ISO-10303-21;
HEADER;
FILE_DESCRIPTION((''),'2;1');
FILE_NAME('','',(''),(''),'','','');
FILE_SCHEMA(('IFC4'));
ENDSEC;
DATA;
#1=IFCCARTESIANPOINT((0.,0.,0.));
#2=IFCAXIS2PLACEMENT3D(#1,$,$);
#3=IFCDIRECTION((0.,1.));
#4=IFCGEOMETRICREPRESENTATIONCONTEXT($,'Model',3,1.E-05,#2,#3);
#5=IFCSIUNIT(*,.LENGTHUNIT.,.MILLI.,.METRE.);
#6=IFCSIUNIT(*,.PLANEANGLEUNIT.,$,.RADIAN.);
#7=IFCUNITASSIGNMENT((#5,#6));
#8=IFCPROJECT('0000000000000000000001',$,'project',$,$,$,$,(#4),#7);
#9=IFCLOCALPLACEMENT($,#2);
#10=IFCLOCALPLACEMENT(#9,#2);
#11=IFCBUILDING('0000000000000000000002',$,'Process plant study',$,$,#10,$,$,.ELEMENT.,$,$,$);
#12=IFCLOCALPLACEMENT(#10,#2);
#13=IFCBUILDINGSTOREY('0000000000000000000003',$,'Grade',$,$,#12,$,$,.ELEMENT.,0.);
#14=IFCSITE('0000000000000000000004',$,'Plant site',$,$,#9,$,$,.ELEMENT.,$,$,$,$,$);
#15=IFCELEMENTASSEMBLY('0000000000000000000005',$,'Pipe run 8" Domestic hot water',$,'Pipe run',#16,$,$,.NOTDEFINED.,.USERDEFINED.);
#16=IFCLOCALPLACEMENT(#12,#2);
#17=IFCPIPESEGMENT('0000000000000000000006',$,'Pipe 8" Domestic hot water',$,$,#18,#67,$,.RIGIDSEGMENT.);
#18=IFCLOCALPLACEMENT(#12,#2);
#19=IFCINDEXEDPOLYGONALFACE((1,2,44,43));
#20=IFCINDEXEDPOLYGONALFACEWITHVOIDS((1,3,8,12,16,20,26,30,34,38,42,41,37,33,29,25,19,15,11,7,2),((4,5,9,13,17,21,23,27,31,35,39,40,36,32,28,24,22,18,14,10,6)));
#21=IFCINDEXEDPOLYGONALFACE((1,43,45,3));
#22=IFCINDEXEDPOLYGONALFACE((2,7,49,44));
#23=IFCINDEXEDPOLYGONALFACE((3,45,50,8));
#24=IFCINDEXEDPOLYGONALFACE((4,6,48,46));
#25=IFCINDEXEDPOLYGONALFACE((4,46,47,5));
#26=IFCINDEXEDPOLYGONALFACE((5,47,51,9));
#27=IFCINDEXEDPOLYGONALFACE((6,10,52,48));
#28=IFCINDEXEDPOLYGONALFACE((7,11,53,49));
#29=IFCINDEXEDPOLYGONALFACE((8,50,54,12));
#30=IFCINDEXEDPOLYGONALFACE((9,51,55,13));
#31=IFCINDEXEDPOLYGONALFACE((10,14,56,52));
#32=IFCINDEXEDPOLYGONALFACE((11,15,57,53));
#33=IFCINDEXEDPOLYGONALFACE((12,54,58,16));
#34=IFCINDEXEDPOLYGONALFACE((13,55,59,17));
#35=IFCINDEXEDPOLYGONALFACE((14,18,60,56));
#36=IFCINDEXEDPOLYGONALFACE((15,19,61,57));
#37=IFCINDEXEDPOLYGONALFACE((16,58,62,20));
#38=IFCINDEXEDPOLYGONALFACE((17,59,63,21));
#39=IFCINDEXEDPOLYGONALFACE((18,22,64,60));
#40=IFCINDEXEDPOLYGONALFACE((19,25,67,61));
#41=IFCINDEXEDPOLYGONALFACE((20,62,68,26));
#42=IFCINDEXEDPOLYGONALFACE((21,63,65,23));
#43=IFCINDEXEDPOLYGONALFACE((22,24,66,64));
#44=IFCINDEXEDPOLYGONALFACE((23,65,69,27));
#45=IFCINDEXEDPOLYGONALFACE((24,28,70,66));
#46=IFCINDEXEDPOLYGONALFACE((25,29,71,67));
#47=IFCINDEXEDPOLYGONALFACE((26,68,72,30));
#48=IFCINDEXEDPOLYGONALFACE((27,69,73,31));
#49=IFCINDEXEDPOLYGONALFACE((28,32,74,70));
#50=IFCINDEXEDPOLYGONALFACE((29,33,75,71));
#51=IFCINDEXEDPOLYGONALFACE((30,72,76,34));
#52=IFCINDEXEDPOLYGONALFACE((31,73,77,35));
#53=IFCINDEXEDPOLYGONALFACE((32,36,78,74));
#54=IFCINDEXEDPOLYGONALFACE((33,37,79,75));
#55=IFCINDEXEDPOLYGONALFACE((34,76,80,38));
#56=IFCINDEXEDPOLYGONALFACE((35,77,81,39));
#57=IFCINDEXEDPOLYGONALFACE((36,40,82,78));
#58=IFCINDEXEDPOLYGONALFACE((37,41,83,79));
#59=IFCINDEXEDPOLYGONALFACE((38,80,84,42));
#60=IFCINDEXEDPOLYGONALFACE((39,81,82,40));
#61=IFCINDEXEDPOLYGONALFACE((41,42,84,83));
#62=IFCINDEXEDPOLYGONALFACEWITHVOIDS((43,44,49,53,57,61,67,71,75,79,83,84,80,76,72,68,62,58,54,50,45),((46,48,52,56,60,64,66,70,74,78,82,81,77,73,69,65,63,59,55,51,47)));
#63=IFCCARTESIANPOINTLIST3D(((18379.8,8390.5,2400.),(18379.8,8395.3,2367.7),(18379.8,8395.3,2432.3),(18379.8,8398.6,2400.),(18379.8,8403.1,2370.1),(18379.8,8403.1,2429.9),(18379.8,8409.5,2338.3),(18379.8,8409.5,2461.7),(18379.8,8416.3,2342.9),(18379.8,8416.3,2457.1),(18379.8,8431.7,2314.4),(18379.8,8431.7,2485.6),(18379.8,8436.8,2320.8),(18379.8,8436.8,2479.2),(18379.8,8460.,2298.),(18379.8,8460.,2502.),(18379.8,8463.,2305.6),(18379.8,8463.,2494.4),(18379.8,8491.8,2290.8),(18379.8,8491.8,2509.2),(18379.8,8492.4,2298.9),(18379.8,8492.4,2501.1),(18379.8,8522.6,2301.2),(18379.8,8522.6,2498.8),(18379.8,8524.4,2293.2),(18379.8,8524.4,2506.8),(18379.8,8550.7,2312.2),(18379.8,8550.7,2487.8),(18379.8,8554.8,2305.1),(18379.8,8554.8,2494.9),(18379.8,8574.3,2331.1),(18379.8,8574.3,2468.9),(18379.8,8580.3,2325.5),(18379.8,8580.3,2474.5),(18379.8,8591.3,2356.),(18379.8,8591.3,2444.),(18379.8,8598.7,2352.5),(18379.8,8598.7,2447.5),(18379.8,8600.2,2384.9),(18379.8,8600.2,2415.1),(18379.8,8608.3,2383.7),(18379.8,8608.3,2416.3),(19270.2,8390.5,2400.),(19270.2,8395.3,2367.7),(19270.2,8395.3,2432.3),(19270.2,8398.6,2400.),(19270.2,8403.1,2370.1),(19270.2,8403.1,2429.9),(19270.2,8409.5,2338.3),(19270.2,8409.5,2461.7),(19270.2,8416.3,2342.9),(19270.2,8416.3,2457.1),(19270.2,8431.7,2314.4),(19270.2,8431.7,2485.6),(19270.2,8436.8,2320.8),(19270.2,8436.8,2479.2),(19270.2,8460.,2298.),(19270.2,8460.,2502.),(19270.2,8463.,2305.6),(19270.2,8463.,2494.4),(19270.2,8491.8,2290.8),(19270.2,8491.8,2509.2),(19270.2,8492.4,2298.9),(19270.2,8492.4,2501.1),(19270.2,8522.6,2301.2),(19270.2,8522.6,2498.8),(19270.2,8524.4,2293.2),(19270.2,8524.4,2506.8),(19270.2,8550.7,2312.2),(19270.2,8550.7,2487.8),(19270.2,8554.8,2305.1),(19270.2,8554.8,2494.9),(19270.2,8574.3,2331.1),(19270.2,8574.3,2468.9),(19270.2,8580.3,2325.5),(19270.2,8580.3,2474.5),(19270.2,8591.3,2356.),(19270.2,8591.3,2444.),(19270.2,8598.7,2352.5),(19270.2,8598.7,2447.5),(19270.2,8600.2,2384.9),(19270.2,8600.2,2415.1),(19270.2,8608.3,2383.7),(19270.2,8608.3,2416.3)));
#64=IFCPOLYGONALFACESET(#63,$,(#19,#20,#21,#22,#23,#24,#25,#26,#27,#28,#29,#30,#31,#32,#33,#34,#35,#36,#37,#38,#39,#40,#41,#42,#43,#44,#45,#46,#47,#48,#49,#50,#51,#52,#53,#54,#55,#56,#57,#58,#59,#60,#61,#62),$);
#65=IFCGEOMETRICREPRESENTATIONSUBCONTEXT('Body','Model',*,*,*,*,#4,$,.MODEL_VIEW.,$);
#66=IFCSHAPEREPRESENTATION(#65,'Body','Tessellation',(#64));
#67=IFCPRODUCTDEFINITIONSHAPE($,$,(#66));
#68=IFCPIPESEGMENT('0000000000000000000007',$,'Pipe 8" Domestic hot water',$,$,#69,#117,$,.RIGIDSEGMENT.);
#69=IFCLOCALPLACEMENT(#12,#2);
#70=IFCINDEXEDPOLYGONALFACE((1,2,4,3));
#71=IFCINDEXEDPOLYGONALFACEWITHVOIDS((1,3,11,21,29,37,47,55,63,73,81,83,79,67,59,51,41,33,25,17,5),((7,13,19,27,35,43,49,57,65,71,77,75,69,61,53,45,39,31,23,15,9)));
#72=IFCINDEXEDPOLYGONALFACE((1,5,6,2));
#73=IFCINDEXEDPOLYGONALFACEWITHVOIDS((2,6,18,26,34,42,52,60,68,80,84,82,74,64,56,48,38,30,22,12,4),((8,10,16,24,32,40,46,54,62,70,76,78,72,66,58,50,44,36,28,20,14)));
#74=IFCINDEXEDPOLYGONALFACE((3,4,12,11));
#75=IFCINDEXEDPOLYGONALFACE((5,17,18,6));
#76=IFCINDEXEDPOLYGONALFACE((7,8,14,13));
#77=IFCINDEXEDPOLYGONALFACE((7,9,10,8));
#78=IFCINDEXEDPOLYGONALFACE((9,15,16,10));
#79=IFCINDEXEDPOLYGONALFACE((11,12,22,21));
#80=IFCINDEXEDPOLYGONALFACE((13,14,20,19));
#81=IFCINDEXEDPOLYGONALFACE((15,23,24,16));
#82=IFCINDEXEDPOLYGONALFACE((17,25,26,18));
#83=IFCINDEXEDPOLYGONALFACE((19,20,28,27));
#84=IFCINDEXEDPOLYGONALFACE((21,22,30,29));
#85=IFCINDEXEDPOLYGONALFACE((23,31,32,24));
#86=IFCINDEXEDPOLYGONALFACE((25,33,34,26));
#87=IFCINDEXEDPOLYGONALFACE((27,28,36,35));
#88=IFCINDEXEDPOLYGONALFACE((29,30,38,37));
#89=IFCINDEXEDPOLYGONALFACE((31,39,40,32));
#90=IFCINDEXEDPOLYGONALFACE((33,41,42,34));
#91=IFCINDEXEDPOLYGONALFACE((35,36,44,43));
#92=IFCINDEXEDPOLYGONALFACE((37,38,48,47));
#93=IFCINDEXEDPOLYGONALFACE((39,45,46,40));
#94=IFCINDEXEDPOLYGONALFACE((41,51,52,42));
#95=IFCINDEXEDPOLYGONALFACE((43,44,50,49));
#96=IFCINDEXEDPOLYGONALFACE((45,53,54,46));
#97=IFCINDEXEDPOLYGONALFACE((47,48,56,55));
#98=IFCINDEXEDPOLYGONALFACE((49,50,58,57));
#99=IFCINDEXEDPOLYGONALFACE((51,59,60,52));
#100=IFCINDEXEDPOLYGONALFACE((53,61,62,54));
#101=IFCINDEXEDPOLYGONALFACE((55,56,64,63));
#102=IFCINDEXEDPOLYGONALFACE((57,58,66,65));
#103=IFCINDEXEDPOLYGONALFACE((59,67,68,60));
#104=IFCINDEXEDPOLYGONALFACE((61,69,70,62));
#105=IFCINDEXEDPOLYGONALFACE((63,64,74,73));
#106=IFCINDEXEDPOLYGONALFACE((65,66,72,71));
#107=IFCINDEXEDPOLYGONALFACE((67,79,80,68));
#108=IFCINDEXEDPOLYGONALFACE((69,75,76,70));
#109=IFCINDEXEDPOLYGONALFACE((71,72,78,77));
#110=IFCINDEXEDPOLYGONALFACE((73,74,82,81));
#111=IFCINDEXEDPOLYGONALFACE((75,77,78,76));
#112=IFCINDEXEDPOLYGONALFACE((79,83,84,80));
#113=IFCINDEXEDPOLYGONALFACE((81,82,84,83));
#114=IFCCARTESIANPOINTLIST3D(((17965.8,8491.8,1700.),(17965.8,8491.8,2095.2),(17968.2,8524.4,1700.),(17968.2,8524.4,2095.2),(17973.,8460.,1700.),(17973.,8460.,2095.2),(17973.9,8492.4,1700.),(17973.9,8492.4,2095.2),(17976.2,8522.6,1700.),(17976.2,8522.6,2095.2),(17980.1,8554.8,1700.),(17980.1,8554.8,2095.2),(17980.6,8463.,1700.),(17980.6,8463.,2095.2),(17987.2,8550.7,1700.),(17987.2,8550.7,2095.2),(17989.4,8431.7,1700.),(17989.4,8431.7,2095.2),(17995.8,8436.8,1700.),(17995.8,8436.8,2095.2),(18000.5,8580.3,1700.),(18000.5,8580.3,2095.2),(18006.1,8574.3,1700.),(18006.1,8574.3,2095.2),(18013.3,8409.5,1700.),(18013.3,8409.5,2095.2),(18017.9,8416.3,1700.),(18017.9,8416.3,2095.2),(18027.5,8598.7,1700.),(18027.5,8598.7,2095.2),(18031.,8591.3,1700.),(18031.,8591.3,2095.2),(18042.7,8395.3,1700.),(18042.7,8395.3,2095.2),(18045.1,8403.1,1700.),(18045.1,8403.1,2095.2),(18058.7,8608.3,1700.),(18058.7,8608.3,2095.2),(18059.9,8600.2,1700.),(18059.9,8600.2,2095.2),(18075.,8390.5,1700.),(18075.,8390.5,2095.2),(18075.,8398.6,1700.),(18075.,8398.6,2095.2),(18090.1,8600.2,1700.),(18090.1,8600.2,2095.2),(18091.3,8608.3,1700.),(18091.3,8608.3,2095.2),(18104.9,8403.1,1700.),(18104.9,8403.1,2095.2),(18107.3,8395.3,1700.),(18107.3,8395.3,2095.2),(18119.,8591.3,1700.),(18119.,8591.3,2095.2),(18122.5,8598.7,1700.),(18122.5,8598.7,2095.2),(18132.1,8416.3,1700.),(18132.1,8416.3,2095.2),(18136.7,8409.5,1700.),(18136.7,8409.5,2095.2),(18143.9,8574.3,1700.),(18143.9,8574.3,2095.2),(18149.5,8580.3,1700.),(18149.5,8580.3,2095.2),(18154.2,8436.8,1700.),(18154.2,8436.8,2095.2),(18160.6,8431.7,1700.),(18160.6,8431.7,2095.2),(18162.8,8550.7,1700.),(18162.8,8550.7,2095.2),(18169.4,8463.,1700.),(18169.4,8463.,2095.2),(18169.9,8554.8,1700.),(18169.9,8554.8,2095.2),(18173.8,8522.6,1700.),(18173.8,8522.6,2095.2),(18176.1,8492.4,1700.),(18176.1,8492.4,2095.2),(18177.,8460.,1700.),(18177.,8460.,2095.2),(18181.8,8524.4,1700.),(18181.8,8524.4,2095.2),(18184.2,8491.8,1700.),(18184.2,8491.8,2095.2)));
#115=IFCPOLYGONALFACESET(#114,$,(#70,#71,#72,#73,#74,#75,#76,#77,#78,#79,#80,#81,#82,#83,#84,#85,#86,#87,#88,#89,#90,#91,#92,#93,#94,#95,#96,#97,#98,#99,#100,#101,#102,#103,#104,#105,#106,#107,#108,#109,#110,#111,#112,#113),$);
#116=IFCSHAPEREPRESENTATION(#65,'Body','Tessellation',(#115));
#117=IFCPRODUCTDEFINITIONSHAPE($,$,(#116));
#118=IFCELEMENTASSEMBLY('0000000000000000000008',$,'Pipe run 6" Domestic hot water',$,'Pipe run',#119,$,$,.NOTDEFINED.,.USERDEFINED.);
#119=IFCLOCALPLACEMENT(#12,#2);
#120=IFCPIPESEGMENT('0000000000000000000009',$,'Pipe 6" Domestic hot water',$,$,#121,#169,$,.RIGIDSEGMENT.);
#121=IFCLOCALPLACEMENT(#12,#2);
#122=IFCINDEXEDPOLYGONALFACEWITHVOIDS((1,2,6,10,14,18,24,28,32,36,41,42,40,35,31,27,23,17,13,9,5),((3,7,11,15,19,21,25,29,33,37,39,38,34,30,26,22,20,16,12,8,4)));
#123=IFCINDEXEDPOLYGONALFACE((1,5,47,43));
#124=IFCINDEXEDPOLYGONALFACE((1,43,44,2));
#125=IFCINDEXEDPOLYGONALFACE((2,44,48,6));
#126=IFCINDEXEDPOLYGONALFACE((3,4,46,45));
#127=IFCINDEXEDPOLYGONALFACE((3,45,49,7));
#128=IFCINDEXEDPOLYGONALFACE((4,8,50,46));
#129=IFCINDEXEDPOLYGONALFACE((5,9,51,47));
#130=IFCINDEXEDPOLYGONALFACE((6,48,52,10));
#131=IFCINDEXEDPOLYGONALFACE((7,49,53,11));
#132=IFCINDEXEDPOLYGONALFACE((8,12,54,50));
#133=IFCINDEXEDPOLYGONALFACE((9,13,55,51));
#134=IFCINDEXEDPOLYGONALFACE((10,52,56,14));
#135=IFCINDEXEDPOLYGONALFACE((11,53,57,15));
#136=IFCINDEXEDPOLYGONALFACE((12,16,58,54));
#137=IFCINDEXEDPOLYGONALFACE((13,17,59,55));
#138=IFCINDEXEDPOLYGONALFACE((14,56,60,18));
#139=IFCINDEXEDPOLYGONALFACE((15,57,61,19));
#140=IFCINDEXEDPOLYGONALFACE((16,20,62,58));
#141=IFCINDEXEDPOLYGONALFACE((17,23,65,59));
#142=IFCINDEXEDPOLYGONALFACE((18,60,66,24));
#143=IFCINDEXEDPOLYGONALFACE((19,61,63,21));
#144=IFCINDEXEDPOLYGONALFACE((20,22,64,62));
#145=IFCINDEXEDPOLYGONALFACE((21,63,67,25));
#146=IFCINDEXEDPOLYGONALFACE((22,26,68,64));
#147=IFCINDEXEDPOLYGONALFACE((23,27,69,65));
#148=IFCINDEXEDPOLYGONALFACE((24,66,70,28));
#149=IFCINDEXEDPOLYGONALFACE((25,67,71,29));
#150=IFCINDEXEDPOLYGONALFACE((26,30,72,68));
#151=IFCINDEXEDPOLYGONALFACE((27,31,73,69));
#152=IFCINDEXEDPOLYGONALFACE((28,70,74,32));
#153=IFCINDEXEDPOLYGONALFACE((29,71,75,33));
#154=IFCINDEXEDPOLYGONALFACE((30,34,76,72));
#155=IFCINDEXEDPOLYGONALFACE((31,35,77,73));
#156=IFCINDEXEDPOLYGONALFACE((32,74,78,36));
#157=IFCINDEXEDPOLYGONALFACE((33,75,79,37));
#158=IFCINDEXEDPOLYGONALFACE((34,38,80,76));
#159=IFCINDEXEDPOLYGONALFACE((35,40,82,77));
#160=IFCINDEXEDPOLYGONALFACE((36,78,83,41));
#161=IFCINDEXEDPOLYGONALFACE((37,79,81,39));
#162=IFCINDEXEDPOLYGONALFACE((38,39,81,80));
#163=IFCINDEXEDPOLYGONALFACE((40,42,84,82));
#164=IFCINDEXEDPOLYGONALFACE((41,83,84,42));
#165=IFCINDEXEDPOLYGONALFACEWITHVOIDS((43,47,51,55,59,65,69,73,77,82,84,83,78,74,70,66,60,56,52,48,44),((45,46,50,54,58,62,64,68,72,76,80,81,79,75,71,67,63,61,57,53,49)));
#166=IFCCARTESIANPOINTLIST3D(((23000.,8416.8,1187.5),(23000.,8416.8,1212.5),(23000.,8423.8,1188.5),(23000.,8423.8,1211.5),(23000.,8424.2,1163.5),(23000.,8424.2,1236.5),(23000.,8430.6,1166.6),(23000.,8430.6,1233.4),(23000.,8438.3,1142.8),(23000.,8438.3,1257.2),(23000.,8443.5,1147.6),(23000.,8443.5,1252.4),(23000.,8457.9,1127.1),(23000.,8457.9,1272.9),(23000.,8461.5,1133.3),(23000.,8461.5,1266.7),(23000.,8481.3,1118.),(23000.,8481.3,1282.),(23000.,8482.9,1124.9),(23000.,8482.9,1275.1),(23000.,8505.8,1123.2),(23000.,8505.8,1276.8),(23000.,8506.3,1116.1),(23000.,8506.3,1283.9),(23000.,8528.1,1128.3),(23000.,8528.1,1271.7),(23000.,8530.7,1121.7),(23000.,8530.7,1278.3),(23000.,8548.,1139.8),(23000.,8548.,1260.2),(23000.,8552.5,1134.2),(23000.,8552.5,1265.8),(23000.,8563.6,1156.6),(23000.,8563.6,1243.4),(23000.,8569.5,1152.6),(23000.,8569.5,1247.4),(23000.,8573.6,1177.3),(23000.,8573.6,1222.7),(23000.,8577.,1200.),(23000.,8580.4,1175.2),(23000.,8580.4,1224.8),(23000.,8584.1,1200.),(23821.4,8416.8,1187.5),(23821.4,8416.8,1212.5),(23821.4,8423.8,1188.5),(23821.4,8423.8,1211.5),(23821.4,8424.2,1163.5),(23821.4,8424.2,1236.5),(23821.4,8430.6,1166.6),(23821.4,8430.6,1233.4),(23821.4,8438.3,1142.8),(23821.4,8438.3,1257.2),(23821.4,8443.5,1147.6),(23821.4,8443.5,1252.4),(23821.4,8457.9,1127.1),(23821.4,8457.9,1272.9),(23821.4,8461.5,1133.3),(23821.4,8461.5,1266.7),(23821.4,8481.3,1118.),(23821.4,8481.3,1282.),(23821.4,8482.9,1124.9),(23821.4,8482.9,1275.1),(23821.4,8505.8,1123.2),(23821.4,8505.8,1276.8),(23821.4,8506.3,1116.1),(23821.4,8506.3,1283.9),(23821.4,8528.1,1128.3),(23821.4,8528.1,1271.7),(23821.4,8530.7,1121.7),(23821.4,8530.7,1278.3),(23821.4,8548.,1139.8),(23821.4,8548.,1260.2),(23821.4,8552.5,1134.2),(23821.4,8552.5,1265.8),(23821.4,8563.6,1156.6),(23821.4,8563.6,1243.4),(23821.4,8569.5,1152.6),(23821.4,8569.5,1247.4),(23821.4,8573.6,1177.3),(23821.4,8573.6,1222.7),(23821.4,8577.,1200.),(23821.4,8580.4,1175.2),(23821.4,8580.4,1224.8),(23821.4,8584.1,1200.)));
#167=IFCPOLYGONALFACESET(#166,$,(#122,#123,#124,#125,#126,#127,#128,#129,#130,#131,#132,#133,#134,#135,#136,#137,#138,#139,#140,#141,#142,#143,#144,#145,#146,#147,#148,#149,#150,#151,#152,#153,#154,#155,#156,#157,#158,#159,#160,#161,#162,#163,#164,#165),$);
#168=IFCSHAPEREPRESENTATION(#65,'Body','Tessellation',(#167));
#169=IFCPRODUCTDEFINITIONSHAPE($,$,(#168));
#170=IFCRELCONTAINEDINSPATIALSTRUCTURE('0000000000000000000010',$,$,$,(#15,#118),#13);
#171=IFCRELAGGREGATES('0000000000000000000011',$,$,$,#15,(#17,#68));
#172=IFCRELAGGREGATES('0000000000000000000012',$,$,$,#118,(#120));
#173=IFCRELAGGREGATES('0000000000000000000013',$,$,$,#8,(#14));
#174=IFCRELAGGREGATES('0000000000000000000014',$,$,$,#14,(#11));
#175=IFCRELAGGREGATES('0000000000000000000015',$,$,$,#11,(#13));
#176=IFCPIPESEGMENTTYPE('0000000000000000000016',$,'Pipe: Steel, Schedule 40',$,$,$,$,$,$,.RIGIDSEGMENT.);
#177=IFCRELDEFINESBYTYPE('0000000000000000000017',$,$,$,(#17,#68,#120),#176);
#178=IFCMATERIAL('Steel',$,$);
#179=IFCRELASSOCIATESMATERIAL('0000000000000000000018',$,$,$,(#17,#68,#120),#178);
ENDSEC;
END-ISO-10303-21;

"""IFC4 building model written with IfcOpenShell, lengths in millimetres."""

from ifc_helpers import new_model, si_unit, direction, frame, origin, origin_with_axes, origin_2d, place, context, subcontext, project, spatial, hollow_circle, extrude, material, type_object, element, aggregate, save


model = new_model("IFC4")

# Units and contexts
model_context = context("Model", 3, precision=1e-05, world=origin(), true_north=direction((0.0, 1.0)))
body_context = subcontext(model_context, "Body", "Model", "MODEL_VIEW")
ifc_project = project(units=[si_unit("LENGTHUNIT", "METRE", prefix="MILLI"), si_unit("PLANEANGLEUNIT", "RADIAN")], contexts=[model_context])

# Site, building, storey
site_placement = place(None, origin())
site = spatial("IfcSite", under=ifc_project, at=site_placement, Name="Plant site", CompositionType="ELEMENT")
building_placement = place(site_placement, origin())
building = spatial("IfcBuilding", under=site, at=building_placement, Name="Process plant study", CompositionType="ELEMENT")
storey_placement = place(building_placement, origin())
storey = spatial("IfcBuildingStorey", under=building, at=storey_placement, Name="Grade", CompositionType="ELEMENT", Elevation=0.0)

# Element assemblies, pipe segments
assembly_1_placement = place(storey_placement, origin_with_axes())
assembly_1 = element("IfcElementAssembly", 1, at=assembly_1_placement, inside=storey, Name="Pipe run 8\" Domestic hot water", ObjectType="Pipe run", AssemblyPlace="NOTDEFINED", PredefinedType="USERDEFINED")
ifc_material = material(Name="Steel")
pipe_segment_type = type_object("IfcPipeSegmentType", Name="Pipe: Steel, Schedule 40", PredefinedType="RIGIDSEGMENT")
pipe_segment_1_placement = place(storey_placement, origin_with_axes())
pipe_segment_1 = element("IfcPipeSegment", 2, at=pipe_segment_1_placement, type_object=pipe_segment_type, material=ifc_material, Name="Pipe 8\" Domestic hot water", PredefinedType="RIGIDSEGMENT", context=body_context, shape_type="SweptSolid", body=[
    extrude(hollow_circle(Radius=109.5, WallThickness=8.2, at=origin_2d()), frame((19270.2, 8500.0, 2400.0), z_axis=(-1.0, 0.0, 0.0), x_axis=(0.0, -1.0, 0.0)), (0.0, 0.0, 1.0), 890.4),
])
pipe_segment_2_placement = place(storey_placement, origin_with_axes())
pipe_segment_2 = element("IfcPipeSegment", 3, at=pipe_segment_2_placement, type_object=pipe_segment_type, material=ifc_material, Name="Pipe 8\" Domestic hot water", PredefinedType="RIGIDSEGMENT", context=body_context, shape_type="SweptSolid", body=[
    extrude(hollow_circle(Radius=109.5, WallThickness=8.2, at=origin_2d()), frame((18075.0, 8500.0, 2095.2), z_axis=(0.0, 0.0, -1.0), x_axis=(0.0, -1.0, 0.0)), (0.0, 0.0, 1.0), 395.2),
])
assembly_2_placement = place(storey_placement, origin_with_axes())
assembly_2 = element("IfcElementAssembly", 4, at=assembly_2_placement, inside=storey, Name="Pipe run 6\" Domestic hot water", ObjectType="Pipe run", AssemblyPlace="NOTDEFINED", PredefinedType="USERDEFINED")
pipe_segment_3_placement = place(storey_placement, origin_with_axes())
pipe_segment_3 = element("IfcPipeSegment", 5, at=pipe_segment_3_placement, type_object=pipe_segment_type, material=ifc_material, Name="Pipe 6\" Domestic hot water", PredefinedType="RIGIDSEGMENT", context=body_context, shape_type="SweptSolid", body=[
    extrude(hollow_circle(Radius=84.1, WallThickness=7.1, at=origin_2d()), frame((23000.0, 8500.0, 1200.0), z_axis=(1.0, 0.0, 0.0), x_axis=(0.0, 1.0, 0.0)), (0.0, 0.0, 1.0), 821.4),
])

aggregate(assembly_1, [pipe_segment_1, pipe_segment_2])
aggregate(assembly_2, [pipe_segment_3])

save(model, "model.ifc")
